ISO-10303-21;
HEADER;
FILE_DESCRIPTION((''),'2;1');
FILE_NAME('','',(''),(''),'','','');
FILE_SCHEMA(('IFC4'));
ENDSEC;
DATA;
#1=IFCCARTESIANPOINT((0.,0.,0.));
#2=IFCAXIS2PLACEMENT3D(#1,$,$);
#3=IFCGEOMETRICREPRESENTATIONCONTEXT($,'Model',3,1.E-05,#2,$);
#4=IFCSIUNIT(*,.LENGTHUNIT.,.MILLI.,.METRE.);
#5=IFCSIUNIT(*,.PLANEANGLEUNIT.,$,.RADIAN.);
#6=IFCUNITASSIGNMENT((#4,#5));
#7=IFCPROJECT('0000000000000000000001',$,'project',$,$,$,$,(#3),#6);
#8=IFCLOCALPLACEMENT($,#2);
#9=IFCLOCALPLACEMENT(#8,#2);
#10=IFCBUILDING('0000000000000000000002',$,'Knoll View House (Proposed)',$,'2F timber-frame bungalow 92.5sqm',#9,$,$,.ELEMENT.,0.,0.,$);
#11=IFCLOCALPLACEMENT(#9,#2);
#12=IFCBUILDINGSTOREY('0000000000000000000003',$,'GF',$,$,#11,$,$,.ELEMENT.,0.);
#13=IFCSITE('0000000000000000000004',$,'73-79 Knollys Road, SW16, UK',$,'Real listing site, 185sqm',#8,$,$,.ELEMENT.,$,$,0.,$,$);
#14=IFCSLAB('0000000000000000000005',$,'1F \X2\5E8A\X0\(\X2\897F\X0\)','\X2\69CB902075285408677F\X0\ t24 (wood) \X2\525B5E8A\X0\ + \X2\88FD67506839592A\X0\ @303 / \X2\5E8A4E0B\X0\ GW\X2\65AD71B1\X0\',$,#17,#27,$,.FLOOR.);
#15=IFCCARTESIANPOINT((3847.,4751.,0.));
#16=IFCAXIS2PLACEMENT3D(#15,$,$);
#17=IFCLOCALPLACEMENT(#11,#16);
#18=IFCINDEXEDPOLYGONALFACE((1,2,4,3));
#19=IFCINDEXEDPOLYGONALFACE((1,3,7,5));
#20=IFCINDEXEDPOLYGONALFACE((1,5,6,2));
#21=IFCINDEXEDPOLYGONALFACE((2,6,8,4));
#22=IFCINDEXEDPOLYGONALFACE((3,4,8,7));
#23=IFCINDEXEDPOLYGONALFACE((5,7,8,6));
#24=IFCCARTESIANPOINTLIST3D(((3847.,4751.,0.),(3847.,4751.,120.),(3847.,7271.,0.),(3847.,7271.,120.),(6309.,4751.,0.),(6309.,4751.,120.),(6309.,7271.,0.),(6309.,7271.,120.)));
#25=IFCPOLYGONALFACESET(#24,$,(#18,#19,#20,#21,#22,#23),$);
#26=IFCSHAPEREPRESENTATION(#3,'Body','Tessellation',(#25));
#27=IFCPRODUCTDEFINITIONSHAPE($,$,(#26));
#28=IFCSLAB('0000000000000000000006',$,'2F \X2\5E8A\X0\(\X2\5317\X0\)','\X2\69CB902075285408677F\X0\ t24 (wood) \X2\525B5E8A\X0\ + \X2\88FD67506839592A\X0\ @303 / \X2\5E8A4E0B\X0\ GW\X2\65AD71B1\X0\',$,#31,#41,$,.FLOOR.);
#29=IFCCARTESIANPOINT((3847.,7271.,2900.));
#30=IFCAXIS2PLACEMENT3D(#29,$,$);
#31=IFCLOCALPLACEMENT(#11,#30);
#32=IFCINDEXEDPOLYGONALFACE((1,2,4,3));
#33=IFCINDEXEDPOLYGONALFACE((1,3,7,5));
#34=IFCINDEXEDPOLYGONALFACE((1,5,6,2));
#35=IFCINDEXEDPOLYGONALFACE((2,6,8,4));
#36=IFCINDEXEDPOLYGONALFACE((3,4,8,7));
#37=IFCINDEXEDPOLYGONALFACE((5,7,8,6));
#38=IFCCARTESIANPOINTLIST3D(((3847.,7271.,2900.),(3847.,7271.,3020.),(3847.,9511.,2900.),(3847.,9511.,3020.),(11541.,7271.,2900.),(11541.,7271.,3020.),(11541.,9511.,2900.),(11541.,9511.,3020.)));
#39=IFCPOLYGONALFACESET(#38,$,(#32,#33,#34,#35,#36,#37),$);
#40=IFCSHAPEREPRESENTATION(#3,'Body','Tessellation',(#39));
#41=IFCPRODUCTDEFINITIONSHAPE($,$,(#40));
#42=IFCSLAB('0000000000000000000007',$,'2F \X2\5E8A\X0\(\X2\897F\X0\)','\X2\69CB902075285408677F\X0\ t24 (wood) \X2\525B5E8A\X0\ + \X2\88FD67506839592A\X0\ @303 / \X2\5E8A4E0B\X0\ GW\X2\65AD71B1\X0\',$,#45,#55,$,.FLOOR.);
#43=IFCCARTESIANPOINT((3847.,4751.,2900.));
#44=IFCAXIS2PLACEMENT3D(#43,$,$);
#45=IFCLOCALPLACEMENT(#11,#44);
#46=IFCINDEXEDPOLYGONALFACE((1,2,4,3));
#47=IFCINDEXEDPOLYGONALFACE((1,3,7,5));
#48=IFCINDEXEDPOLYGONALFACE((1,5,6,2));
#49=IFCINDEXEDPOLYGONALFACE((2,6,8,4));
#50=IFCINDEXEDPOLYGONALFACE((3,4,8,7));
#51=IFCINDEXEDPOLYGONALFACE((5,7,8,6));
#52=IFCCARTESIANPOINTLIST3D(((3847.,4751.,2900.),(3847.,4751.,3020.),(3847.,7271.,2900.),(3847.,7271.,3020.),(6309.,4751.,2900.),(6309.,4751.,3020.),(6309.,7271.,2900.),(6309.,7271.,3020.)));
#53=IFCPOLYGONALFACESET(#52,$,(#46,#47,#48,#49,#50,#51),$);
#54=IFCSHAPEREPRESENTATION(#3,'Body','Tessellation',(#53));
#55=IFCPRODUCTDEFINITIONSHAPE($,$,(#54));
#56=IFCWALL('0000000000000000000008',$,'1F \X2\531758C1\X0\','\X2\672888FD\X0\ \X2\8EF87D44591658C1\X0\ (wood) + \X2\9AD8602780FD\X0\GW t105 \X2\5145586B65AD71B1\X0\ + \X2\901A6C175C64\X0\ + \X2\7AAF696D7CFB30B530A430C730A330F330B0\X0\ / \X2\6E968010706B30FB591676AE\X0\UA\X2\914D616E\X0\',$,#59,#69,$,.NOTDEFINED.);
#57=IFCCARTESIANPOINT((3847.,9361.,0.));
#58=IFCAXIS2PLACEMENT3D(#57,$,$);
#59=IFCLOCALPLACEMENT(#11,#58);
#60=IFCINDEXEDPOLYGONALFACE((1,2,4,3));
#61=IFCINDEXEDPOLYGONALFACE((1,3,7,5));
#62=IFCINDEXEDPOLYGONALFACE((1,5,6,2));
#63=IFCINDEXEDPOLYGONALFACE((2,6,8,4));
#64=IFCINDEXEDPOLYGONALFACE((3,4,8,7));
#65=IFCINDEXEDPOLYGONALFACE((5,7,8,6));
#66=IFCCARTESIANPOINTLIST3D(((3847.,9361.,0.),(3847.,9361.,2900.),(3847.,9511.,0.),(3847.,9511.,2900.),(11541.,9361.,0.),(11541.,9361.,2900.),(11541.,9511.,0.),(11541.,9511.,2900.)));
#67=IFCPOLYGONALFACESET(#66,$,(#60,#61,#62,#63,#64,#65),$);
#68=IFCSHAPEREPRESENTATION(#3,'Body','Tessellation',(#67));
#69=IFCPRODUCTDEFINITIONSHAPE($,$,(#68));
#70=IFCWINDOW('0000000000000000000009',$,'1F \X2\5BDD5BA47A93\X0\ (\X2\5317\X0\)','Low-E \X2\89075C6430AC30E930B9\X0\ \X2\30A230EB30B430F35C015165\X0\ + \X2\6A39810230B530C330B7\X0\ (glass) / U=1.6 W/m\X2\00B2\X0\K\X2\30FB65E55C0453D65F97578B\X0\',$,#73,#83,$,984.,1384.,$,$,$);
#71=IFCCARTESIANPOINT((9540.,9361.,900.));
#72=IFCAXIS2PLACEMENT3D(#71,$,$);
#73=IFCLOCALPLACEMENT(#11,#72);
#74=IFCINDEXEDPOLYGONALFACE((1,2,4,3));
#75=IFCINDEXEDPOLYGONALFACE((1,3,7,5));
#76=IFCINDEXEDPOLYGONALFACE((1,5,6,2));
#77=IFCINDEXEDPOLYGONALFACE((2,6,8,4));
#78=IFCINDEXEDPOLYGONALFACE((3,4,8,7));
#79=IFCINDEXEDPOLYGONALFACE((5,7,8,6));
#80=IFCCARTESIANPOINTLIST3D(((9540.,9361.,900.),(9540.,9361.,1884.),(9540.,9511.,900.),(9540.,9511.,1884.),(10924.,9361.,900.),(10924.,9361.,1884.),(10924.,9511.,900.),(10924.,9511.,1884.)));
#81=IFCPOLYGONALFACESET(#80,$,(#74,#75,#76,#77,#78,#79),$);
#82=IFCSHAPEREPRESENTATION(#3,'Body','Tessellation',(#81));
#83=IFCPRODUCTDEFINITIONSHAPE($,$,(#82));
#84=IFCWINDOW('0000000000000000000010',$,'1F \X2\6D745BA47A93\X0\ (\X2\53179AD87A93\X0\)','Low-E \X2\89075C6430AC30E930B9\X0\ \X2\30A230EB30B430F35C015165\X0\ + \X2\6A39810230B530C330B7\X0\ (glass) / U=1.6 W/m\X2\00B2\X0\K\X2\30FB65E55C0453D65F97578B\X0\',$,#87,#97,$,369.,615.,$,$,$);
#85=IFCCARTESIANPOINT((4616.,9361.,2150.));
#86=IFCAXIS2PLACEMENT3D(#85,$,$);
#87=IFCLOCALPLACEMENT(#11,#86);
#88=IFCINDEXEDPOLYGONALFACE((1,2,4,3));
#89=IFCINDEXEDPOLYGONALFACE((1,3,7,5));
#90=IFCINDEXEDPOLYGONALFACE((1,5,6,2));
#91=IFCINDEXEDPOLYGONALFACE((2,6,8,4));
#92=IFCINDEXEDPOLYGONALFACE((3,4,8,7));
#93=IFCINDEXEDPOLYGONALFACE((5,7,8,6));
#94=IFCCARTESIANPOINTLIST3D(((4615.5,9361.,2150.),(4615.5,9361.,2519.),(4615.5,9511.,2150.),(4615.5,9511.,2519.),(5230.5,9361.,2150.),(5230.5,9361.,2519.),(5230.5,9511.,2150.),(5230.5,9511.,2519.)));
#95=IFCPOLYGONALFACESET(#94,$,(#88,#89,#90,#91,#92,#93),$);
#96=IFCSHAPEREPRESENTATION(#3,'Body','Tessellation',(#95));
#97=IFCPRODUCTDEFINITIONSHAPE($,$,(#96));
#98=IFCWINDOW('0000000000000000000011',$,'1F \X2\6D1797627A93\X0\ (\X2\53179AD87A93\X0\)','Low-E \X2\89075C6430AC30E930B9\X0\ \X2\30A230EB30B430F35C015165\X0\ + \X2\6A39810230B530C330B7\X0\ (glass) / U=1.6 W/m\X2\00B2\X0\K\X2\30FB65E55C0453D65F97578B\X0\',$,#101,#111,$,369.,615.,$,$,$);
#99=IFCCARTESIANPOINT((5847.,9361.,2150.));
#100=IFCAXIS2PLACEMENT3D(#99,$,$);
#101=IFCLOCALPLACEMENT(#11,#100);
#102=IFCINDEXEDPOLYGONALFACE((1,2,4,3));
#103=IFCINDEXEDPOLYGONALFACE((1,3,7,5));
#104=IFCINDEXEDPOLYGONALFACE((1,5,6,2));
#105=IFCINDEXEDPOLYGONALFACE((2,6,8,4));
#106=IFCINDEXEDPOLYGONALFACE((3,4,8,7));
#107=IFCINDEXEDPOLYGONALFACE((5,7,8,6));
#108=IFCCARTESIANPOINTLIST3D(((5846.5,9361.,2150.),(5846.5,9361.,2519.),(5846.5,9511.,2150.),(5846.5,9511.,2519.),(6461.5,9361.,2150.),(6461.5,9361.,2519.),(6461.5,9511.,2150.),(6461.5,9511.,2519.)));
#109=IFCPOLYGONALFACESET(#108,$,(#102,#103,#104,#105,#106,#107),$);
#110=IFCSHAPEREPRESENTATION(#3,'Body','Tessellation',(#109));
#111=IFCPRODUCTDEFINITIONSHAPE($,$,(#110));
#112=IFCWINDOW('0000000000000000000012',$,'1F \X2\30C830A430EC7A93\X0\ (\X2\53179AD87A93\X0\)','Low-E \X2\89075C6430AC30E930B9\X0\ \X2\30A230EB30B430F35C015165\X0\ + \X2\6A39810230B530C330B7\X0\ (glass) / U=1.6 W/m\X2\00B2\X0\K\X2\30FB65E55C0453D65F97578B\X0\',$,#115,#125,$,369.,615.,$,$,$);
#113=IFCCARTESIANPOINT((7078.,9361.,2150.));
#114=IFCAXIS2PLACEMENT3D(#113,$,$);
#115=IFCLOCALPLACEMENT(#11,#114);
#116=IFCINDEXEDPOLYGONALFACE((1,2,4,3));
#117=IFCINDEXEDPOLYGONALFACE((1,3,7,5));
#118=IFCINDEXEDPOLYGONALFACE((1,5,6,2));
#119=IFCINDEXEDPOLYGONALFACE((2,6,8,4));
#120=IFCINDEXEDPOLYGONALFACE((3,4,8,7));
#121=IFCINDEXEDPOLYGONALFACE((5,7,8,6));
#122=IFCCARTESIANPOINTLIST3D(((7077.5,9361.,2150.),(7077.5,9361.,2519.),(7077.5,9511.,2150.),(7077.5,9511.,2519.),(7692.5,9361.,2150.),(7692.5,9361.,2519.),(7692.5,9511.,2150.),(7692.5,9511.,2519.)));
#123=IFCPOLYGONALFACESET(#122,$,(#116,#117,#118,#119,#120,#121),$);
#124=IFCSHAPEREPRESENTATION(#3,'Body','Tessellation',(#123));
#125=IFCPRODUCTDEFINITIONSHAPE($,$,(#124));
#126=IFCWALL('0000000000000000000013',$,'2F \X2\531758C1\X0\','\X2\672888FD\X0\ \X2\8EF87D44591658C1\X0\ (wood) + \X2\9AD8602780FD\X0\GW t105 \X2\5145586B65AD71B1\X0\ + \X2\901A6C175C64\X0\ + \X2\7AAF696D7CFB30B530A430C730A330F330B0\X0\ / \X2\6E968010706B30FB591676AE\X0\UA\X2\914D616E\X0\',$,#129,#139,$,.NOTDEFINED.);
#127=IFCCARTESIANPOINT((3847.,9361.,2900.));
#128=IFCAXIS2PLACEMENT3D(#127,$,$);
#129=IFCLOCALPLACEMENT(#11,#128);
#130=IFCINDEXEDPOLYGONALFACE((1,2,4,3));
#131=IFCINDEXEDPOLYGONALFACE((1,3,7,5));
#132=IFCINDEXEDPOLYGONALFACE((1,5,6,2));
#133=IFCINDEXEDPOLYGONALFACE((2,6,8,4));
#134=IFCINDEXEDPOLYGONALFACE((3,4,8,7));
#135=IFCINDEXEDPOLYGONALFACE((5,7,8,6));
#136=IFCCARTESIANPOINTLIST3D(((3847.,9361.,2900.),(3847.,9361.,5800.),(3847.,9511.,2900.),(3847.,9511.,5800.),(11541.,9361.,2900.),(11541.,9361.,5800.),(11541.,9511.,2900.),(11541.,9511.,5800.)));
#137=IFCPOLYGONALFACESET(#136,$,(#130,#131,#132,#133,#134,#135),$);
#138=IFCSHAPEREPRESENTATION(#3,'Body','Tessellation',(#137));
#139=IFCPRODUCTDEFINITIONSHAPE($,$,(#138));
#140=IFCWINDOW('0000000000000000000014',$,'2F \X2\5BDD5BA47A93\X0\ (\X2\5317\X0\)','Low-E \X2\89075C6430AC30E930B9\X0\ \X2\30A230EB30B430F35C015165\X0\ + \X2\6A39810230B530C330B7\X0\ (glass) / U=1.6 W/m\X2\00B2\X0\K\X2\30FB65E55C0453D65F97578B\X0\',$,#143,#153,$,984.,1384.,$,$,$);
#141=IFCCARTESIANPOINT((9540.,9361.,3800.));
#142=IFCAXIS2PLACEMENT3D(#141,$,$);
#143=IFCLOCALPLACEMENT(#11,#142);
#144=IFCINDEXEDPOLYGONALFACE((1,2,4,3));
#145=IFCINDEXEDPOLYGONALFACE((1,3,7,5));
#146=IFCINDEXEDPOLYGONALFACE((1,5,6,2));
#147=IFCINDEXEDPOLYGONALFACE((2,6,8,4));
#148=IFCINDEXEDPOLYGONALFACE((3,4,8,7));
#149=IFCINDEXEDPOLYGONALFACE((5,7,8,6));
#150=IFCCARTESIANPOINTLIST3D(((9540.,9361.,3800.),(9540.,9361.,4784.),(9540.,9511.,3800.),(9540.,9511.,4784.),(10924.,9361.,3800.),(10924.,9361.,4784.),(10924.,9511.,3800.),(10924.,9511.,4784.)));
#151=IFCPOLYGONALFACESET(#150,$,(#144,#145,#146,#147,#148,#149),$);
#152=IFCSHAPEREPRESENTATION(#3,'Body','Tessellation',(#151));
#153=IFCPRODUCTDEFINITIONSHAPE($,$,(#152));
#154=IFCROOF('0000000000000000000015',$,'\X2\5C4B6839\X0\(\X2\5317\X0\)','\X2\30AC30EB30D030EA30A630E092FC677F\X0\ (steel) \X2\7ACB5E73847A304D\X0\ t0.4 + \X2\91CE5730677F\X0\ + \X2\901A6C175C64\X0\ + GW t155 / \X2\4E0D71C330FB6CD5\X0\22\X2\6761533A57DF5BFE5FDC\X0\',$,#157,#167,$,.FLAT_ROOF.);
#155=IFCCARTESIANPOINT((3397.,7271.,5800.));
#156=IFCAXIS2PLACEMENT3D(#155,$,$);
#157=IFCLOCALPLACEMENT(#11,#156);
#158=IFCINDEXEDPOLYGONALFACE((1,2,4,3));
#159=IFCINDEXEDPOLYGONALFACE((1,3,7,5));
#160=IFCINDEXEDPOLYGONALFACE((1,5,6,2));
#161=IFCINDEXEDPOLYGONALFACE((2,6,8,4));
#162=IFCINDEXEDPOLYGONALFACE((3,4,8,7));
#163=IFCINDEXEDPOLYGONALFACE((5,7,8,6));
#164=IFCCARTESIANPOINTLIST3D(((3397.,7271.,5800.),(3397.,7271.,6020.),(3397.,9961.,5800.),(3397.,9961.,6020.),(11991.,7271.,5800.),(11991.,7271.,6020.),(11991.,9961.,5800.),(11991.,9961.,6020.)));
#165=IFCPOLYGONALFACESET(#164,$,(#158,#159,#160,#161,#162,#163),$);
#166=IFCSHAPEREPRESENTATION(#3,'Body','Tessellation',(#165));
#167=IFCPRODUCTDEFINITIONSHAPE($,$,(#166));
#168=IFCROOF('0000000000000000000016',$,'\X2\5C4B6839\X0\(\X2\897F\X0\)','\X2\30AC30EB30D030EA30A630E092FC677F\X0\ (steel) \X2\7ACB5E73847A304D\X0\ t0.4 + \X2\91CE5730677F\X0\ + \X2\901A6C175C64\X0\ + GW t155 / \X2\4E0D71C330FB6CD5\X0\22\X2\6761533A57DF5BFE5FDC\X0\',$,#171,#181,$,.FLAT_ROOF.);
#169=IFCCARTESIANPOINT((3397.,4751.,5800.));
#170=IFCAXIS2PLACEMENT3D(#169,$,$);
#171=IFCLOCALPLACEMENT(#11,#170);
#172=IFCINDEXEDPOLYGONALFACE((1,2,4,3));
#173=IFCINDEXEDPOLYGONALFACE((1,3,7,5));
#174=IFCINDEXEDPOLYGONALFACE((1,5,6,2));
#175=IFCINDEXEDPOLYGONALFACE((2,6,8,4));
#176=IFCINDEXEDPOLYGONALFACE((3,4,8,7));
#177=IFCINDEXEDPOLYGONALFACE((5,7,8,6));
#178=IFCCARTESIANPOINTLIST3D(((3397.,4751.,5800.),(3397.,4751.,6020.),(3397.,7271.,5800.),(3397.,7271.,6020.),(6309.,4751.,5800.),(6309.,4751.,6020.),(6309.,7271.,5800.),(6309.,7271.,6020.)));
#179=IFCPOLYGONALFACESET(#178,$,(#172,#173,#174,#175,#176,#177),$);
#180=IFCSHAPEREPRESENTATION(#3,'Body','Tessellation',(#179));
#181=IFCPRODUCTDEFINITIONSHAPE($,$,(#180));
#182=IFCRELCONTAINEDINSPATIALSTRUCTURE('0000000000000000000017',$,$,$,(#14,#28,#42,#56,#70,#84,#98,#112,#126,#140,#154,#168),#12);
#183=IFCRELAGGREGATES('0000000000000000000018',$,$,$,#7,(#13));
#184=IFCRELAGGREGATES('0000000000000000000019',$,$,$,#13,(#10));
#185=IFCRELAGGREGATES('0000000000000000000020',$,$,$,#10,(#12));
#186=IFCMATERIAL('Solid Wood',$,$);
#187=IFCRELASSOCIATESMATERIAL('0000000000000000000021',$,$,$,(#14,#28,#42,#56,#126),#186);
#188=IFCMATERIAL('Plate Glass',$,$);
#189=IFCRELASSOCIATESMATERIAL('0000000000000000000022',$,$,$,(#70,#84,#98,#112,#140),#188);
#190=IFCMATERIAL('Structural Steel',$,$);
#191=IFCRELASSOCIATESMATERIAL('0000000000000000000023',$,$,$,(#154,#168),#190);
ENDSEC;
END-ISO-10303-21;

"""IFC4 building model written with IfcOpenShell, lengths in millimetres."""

from ifc_helpers import new_model, si_unit, frame, frame_2d, origin, place, context, project, spatial, rectangle, extrude, material, element, fill, save


model = new_model("IFC4")

# Units and contexts
model_context = context("Model", 3, precision=1e-05, world=origin())
ifc_project = project(units=[si_unit("LENGTHUNIT", "METRE", prefix="MILLI"), si_unit("PLANEANGLEUNIT", "RADIAN")], contexts=[model_context])

# Site, building, storey
site_placement = place(None, origin())
site = spatial("IfcSite", under=ifc_project, at=site_placement, Name="73-79 Knollys Road, SW16, UK", ObjectType="Real listing site, 185sqm", CompositionType="ELEMENT", RefElevation=0.0)
building_placement = place(site_placement, origin())
building = spatial("IfcBuilding", under=site, at=building_placement, Name="Knoll View House (Proposed)", ObjectType="2F timber-frame bungalow 92.5sqm", CompositionType="ELEMENT", ElevationOfRefHeight=0.0, ElevationOfTerrain=0.0)
storey_placement = place(building_placement, origin())
storey = spatial("IfcBuildingStorey", under=building, at=storey_placement, Name="GF", CompositionType="ELEMENT", Elevation=0.0)

# Slabs
ifc_material_1 = material(Name="Solid Wood")
slab_1_placement = place(storey_placement, frame((3847.0, 4751.0, 0.0)))
element("IfcSlab", 1, at=slab_1_placement, inside=storey, material=ifc_material_1, Name="1F 床(西)", Description="構造用合板 t24 (wood) 剛床 + 製材根太 @303 / 床下 GW断熱", PredefinedType="FLOOR", context=model_context, shape_type="SweptSolid", body=[
    extrude(rectangle(XDim=2462.0, YDim=2520.0, at=frame_2d((1231.0, 1260.0))), frame((3847.0, 4751.0, 0.0)), (0.0, 0.0, 1.0), 120.0),
])
slab_2_placement = place(storey_placement, frame((3847.0, 7271.0, 2900.0)))
element("IfcSlab", 2, at=slab_2_placement, inside=storey, material=ifc_material_1, Name="2F 床(北)", Description="構造用合板 t24 (wood) 剛床 + 製材根太 @303 / 床下 GW断熱", PredefinedType="FLOOR", context=model_context, shape_type="SweptSolid", body=[
    extrude(rectangle(XDim=7694.0, YDim=2240.0, at=frame_2d((3847.0, 1120.0))), frame((3847.0, 7271.0, 2900.0)), (0.0, 0.0, 1.0), 120.0),
])
slab_3_placement = place(storey_placement, frame((3847.0, 4751.0, 2900.0)))
element("IfcSlab", 3, at=slab_3_placement, inside=storey, material=ifc_material_1, Name="2F 床(西)", Description="構造用合板 t24 (wood) 剛床 + 製材根太 @303 / 床下 GW断熱", PredefinedType="FLOOR", context=model_context, shape_type="SweptSolid", body=[
    extrude(rectangle(XDim=2462.0, YDim=2520.0, at=frame_2d((1231.0, 1260.0))), frame((3847.0, 4751.0, 2900.0)), (0.0, 0.0, 1.0), 120.0),
])

# Wall, openings, windows
wall_1_placement = place(storey_placement, frame((3847.0, 9361.0, 0.0)))
wall_1 = element("IfcWall", 4, at=wall_1_placement, inside=storey, material=ifc_material_1, Name="1F 北壁", Description="木製 軸組外壁 (wood) + 高性能GW t105 充填断熱 + 通気層 + 窯業系サイディング / 準耐火・外皮UA配慮", PredefinedType="NOTDEFINED", context=model_context, shape_type="SweptSolid", body=[
    extrude(rectangle(XDim=7694.0, YDim=150.0, at=frame_2d((3847.0, 75.0))), frame((3847.0, 9361.0, 0.0)), (0.0, 0.0, 1.0), 2900.0),
])
opening_1_placement = place(storey_placement, frame((9540.0, 9361.0, 900.0)))
opening_1 = element("IfcOpeningElement", 5, at=opening_1_placement, cuts=wall_1, PredefinedType="NOTDEFINED", context=model_context, shape_type="SweptSolid", body=[
    extrude(rectangle(XDim=1384.0, YDim=150.0, at=frame_2d((692.0, 75.0))), frame((9540.0, 9361.0, 900.0)), (0.0, 0.0, 1.0), 984.0),
])
opening_2_placement = place(storey_placement, frame((4616.0, 9361.0, 2150.0)))
opening_2 = element("IfcOpeningElement", 6, at=opening_2_placement, cuts=wall_1, PredefinedType="NOTDEFINED", context=model_context, shape_type="SweptSolid", body=[
    extrude(rectangle(XDim=615.0, YDim=150.0, at=frame_2d((307.0, 75.0))), frame((4616.0, 9361.0, 2150.0)), (0.0, 0.0, 1.0), 369.0),
])
opening_3_placement = place(storey_placement, frame((5847.0, 9361.0, 2150.0)))
opening_3 = element("IfcOpeningElement", 7, at=opening_3_placement, cuts=wall_1, PredefinedType="NOTDEFINED", context=model_context, shape_type="SweptSolid", body=[
    extrude(rectangle(XDim=615.0, YDim=150.0, at=frame_2d((307.0, 75.0))), frame((5847.0, 9361.0, 2150.0)), (0.0, 0.0, 1.0), 369.0),
])
opening_4_placement = place(storey_placement, frame((7078.0, 9361.0, 2150.0)))
opening_4 = element("IfcOpeningElement", 8, at=opening_4_placement, cuts=wall_1, PredefinedType="NOTDEFINED", context=model_context, shape_type="SweptSolid", body=[
    extrude(rectangle(XDim=615.0, YDim=150.0, at=frame_2d((307.0, 75.0))), frame((7078.0, 9361.0, 2150.0)), (0.0, 0.0, 1.0), 369.0),
])
ifc_material_2 = material(Name="Plate Glass")
window_1_placement = place(storey_placement, frame((9540.0, 9361.0, 900.0)))
window_1 = element("IfcWindow", 9, at=window_1_placement, inside=storey, material=ifc_material_2, Name="1F 寝室窓 (北)", Description="Low-E 複層ガラス アルゴン封入 + 樹脂サッシ (glass) / U=1.6 W/m²K・日射取得型", OverallHeight=984.0, OverallWidth=1384.0, context=model_context, shape_type="SweptSolid", body=[
    extrude(rectangle(XDim=1384.0, YDim=150.0, at=frame_2d((692.0, 75.0))), frame((9540.0, 9361.0, 900.0)), (0.0, 0.0, 1.0), 984.0),
])
fill(opening_1, window_1)
window_2_placement = place(storey_placement, frame((4616.0, 9361.0, 2150.0)))
window_2 = element("IfcWindow", 10, at=window_2_placement, inside=storey, material=ifc_material_2, Name="1F 浴室窓 (北高窓)", Description="Low-E 複層ガラス アルゴン封入 + 樹脂サッシ (glass) / U=1.6 W/m²K・日射取得型", OverallHeight=369.0, OverallWidth=615.0, context=model_context, shape_type="SweptSolid", body=[
    extrude(rectangle(XDim=615.0, YDim=150.0, at=frame_2d((307.0, 75.0))), frame((4616.0, 9361.0, 2150.0)), (0.0, 0.0, 1.0), 369.0),
])
fill(opening_2, window_2)
window_3_placement = place(storey_placement, frame((5847.0, 9361.0, 2150.0)))
window_3 = element("IfcWindow", 11, at=window_3_placement, inside=storey, material=ifc_material_2, Name="1F 洗面窓 (北高窓)", Description="Low-E 複層ガラス アルゴン封入 + 樹脂サッシ (glass) / U=1.6 W/m²K・日射取得型", OverallHeight=369.0, OverallWidth=615.0, context=model_context, shape_type="SweptSolid", body=[
    extrude(rectangle(XDim=615.0, YDim=150.0, at=frame_2d((307.0, 75.0))), frame((5847.0, 9361.0, 2150.0)), (0.0, 0.0, 1.0), 369.0),
])
fill(opening_3, window_3)
window_4_placement = place(storey_placement, frame((7078.0, 9361.0, 2150.0)))
window_4 = element("IfcWindow", 12, at=window_4_placement, inside=storey, material=ifc_material_2, Name="1F トイレ窓 (北高窓)", Description="Low-E 複層ガラス アルゴン封入 + 樹脂サッシ (glass) / U=1.6 W/m²K・日射取得型", OverallHeight=369.0, OverallWidth=615.0, context=model_context, shape_type="SweptSolid", body=[
    extrude(rectangle(XDim=615.0, YDim=150.0, at=frame_2d((307.0, 75.0))), frame((7078.0, 9361.0, 2150.0)), (0.0, 0.0, 1.0), 369.0),
])
fill(opening_4, window_4)

# Wall, opening, window
wall_2_placement = place(storey_placement, frame((3847.0, 9361.0, 2900.0)))
wall_2 = element("IfcWall", 13, at=wall_2_placement, inside=storey, material=ifc_material_1, Name="2F 北壁", Description="木製 軸組外壁 (wood) + 高性能GW t105 充填断熱 + 通気層 + 窯業系サイディング / 準耐火・外皮UA配慮", PredefinedType="NOTDEFINED", context=model_context, shape_type="SweptSolid", body=[
    extrude(rectangle(XDim=7694.0, YDim=150.0, at=frame_2d((3847.0, 75.0))), frame((3847.0, 9361.0, 2900.0)), (0.0, 0.0, 1.0), 2900.0),
])
opening_5_placement = place(storey_placement, frame((9540.0, 9361.0, 3800.0)))
opening_5 = element("IfcOpeningElement", 14, at=opening_5_placement, cuts=wall_2, PredefinedType="NOTDEFINED", context=model_context, shape_type="SweptSolid", body=[
    extrude(rectangle(XDim=1384.0, YDim=150.0, at=frame_2d((692.0, 75.0))), frame((9540.0, 9361.0, 3800.0)), (0.0, 0.0, 1.0), 984.0),
])
window_5_placement = place(storey_placement, frame((9540.0, 9361.0, 3800.0)))
window_5 = element("IfcWindow", 15, at=window_5_placement, inside=storey, material=ifc_material_2, Name="2F 寝室窓 (北)", Description="Low-E 複層ガラス アルゴン封入 + 樹脂サッシ (glass) / U=1.6 W/m²K・日射取得型", OverallHeight=984.0, OverallWidth=1384.0, context=model_context, shape_type="SweptSolid", body=[
    extrude(rectangle(XDim=1384.0, YDim=150.0, at=frame_2d((692.0, 75.0))), frame((9540.0, 9361.0, 3800.0)), (0.0, 0.0, 1.0), 984.0),
])
fill(opening_5, window_5)

# Roofs
ifc_material_3 = material(Name="Structural Steel")
for number, where, name in (
    (16, (3397.0, 7271.0, 5800.0), "屋根(北)"),
):
    element("IfcRoof", number, at=place(storey_placement, frame(where)), inside=storey, material=ifc_material_3, Name=name, Description="ガルバリウム鋼板 (steel) 立平葺き t0.4 + 野地板 + 通気層 + GW t155 / 不燃・法22条区域対応", PredefinedType="FLAT_ROOF", context=model_context, shape_type="SweptSolid", body=[
        extrude(rectangle(XDim=8594.0, YDim=2690.0, at=frame_2d((4297.0, 1345.0))), frame((3397.0, 7271.0, 5800.0)), (0.0, 0.0, 1.0), 220.0),
    ])
roof_placement = place(storey_placement, frame((3397.0, 4751.0, 5800.0)))
element("IfcRoof", 17, at=roof_placement, inside=storey, material=ifc_material_3, Name="屋根(西)", Description="ガルバリウム鋼板 (steel) 立平葺き t0.4 + 野地板 + 通気層 + GW t155 / 不燃・法22条区域対応", PredefinedType="FLAT_ROOF", context=model_context, shape_type="SweptSolid", body=[
    extrude(rectangle(XDim=2912.0, YDim=2520.0, at=frame_2d((1456.0, 1260.0))), frame((3397.0, 4751.0, 5800.0)), (0.0, 0.0, 1.0), 220.0),
])

save(model, "model.ifc")
